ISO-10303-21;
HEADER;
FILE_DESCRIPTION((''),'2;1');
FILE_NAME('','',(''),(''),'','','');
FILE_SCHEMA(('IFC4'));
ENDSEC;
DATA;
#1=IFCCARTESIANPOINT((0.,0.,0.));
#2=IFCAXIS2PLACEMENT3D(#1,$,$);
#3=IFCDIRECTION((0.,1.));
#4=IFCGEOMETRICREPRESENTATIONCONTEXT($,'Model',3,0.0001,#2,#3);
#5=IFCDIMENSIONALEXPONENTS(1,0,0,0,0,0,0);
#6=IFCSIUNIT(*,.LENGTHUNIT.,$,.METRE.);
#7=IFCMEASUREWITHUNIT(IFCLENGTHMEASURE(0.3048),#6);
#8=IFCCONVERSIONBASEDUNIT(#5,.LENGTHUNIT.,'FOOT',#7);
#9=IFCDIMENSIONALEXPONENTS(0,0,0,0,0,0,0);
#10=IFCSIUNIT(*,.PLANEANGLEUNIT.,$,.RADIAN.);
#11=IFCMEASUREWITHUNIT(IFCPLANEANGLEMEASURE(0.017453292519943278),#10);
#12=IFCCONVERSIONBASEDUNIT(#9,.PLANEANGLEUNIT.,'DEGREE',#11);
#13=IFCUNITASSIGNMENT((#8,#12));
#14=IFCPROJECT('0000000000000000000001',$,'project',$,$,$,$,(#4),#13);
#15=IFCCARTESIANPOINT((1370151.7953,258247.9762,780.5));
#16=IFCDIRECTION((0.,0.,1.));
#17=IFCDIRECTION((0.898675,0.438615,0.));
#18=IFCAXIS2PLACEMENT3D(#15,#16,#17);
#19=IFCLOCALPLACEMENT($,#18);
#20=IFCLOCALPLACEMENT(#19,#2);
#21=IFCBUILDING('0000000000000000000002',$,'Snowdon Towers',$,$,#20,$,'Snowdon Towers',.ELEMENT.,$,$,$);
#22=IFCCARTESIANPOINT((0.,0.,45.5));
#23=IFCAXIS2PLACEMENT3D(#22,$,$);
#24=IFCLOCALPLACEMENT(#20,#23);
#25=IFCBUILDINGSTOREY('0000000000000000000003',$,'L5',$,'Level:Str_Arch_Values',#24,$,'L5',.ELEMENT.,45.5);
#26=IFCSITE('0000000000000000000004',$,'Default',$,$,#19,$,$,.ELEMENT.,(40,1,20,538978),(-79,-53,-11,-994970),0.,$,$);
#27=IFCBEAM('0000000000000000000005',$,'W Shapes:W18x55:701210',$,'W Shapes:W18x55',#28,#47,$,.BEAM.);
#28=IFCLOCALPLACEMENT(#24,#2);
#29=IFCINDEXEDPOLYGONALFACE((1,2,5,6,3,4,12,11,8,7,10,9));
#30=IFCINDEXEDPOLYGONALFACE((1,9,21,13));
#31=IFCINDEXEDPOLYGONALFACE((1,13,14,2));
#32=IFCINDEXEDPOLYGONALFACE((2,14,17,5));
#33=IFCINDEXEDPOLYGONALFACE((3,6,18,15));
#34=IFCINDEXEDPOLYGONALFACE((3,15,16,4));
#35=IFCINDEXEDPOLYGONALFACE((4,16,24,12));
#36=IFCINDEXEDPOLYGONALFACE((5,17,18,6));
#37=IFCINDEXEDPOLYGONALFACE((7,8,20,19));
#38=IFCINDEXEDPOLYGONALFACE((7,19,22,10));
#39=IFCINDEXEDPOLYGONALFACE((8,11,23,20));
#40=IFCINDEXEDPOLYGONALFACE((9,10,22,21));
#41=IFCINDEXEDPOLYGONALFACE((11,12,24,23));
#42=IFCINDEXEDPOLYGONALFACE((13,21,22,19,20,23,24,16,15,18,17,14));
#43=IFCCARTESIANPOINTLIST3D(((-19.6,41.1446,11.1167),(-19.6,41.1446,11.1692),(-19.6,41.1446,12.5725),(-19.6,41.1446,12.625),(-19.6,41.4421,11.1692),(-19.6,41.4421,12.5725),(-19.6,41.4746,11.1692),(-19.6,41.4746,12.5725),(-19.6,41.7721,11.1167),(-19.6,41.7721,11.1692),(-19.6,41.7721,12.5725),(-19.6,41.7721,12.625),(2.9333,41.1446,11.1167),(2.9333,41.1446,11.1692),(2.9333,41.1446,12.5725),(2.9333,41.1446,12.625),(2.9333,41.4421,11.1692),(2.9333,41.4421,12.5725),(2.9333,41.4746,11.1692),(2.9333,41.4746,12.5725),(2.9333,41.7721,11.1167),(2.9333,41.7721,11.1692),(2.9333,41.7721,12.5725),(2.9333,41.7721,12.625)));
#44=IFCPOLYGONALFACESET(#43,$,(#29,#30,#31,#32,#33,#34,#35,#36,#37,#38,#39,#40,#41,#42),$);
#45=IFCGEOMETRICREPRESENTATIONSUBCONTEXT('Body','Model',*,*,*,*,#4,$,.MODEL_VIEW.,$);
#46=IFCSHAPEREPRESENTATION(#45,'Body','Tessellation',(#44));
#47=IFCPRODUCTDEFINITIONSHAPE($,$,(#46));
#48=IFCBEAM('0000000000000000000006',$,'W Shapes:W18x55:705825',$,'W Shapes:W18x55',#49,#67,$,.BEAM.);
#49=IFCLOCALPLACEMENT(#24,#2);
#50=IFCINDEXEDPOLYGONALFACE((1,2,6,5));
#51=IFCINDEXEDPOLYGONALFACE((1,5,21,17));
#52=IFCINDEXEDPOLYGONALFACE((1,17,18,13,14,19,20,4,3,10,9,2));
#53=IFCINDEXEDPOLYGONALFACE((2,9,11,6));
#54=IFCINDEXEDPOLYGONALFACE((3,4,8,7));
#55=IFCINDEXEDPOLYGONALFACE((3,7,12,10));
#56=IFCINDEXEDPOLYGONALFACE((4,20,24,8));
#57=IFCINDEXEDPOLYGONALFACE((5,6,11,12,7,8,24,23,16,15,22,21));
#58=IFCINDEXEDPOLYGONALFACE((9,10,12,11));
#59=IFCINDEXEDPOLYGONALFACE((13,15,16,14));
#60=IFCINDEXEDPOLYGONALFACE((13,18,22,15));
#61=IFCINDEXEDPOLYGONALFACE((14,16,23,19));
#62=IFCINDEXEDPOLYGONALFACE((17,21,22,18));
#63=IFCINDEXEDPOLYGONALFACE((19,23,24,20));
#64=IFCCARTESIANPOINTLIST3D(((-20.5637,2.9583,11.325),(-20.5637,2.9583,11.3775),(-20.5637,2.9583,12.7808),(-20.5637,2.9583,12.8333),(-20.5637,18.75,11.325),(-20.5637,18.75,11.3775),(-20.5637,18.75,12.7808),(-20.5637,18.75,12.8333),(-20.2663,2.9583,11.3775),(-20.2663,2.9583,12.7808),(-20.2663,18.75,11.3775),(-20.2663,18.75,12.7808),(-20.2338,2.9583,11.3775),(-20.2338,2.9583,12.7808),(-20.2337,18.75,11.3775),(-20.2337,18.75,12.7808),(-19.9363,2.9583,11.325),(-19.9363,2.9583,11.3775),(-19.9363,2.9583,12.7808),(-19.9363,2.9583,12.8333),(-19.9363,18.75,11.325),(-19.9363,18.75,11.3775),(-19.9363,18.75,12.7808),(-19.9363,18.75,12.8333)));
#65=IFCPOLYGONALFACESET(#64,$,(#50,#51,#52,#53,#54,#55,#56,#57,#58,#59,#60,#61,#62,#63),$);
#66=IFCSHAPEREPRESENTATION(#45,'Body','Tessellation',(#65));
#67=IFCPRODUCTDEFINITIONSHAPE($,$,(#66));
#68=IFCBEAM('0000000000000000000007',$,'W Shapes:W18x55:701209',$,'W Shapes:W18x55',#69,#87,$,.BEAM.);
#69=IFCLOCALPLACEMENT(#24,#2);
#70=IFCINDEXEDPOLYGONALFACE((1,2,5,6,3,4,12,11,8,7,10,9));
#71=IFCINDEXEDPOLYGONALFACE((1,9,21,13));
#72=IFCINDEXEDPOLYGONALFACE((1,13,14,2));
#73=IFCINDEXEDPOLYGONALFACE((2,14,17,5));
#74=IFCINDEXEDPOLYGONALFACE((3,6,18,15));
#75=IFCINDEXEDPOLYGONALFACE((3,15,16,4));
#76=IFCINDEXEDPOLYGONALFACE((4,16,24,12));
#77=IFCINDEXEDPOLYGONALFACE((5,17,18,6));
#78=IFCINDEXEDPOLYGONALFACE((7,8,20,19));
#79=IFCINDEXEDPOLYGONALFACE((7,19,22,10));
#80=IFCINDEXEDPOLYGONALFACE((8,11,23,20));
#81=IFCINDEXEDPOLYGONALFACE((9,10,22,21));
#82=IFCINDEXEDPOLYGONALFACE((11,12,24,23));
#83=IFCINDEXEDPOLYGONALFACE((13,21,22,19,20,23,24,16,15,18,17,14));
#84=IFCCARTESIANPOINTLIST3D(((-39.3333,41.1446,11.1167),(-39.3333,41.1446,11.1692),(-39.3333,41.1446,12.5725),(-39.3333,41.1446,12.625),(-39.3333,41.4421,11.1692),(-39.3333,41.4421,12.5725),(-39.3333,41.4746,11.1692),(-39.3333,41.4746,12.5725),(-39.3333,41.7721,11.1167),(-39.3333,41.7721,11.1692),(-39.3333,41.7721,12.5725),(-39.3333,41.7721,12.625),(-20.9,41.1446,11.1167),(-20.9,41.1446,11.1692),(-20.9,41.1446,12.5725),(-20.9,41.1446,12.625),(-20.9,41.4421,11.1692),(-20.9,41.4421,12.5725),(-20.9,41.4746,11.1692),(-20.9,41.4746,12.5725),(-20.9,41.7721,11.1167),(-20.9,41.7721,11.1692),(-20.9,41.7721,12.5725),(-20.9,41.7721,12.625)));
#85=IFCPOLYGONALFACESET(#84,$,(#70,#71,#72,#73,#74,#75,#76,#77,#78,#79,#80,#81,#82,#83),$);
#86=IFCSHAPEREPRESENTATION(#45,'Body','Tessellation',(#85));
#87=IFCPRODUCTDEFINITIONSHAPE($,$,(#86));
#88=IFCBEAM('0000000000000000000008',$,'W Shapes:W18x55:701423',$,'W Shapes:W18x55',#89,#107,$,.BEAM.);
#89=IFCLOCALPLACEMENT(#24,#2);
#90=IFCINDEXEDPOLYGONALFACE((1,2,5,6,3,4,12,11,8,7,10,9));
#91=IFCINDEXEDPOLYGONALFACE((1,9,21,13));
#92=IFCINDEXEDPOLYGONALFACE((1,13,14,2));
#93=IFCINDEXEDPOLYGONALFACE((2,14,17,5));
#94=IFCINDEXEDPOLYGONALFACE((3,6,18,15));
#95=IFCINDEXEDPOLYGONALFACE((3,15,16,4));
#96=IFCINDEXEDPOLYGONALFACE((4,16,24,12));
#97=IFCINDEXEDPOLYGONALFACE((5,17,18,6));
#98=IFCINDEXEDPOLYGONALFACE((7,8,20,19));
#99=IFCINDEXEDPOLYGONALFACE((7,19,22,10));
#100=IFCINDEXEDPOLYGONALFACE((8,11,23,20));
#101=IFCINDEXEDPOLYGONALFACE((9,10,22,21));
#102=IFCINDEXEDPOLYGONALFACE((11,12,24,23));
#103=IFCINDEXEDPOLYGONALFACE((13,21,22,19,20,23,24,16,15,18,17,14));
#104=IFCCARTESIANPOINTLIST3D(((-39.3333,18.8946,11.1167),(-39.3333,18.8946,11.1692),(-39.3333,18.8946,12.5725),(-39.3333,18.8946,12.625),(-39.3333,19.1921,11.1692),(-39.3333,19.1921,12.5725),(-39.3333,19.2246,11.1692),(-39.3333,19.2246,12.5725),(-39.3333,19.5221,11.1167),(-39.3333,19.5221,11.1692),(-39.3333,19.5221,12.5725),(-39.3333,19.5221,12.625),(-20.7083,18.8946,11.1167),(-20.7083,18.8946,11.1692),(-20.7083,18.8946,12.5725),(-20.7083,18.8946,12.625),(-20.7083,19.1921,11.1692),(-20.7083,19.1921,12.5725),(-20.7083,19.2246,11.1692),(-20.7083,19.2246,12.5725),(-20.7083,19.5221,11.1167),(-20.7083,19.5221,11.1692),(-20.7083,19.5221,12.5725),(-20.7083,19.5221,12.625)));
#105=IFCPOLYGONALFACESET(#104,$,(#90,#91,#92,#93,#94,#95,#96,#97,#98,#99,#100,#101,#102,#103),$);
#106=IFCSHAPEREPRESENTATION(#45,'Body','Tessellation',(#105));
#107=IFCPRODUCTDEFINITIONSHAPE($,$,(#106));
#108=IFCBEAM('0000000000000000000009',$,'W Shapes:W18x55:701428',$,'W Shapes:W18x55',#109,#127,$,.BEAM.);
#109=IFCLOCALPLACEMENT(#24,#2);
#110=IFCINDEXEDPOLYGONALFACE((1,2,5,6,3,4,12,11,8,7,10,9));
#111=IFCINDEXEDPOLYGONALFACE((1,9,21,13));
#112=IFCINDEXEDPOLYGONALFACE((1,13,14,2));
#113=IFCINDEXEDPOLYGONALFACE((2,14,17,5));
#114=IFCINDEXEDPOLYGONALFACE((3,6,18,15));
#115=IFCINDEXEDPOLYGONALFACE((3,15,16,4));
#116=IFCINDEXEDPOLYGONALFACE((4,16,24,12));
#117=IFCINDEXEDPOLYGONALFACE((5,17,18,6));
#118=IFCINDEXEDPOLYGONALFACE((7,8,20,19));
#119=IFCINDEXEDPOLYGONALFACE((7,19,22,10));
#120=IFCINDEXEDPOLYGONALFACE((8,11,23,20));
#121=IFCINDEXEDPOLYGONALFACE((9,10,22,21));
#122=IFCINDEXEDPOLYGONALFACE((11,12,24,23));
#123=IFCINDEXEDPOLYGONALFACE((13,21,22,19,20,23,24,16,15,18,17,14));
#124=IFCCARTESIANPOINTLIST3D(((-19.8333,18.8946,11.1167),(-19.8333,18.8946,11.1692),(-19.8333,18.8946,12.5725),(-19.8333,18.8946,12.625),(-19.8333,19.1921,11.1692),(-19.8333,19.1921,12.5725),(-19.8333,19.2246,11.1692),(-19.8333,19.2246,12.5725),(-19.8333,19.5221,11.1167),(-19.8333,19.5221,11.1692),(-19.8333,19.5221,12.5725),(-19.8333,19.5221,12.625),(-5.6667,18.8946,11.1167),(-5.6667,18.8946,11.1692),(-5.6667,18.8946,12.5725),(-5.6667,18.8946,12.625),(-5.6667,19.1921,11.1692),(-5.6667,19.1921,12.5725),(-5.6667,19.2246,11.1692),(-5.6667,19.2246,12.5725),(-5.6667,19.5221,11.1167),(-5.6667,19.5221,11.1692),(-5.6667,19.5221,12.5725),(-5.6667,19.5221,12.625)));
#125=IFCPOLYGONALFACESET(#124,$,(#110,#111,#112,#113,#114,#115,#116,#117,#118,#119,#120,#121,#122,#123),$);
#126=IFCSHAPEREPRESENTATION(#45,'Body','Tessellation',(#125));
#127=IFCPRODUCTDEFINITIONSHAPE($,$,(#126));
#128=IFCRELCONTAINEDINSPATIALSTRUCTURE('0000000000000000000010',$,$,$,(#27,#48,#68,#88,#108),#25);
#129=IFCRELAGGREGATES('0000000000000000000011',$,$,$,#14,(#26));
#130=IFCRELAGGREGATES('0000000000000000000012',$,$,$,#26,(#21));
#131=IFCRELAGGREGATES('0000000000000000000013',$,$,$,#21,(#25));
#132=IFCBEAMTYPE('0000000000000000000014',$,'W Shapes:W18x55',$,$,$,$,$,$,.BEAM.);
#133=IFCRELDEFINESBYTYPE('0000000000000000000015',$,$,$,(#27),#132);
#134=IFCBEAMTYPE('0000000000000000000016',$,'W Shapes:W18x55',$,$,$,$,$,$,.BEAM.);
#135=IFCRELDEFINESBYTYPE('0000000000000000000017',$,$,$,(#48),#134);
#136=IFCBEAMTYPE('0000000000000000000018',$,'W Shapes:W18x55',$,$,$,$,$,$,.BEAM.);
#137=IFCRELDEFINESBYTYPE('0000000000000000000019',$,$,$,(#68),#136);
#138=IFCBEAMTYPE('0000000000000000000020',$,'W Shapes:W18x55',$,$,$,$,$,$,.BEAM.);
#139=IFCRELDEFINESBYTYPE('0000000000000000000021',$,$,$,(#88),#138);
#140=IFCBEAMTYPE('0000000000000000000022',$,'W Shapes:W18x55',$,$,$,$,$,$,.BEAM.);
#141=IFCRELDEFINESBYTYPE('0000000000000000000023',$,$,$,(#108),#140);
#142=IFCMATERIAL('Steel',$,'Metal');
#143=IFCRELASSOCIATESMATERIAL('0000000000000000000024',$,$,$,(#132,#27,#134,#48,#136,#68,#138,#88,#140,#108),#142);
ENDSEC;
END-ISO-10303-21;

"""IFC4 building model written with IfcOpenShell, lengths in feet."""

from ifc_helpers import new_model, entity, si_unit, converted_unit, direction, frame, origin, place, context, subcontext, project, spatial, indexed_curve, outline, extrude, source, transform, mapped, material, type_object, type_shapes, element, save


model = new_model("IFC4")

# Units and contexts
model_context = context("Model", 3, precision=0.0001, world=origin(), true_north=direction((0.0, 1.0)))
body_context = subcontext(model_context, "Body", "Model", "MODEL_VIEW")
ifc_project = project(units=[converted_unit("LENGTHUNIT", "FOOT", entity("IfcLengthMeasure", 0.3048), si_unit("LENGTHUNIT", "METRE"), dimensions=[1, 0, 0, 0, 0, 0, 0]), converted_unit("PLANEANGLEUNIT", "DEGREE", entity("IfcPlaneAngleMeasure", 0.017453292519943278), si_unit("PLANEANGLEUNIT", "RADIAN"), dimensions=[0, 0, 0, 0, 0, 0, 0])], contexts=[model_context])

# Site, building, storey
site_placement = place(None, frame((1370151.7953, 258247.9762, 780.5), z_axis=(0.0, 0.0, 1.0), x_axis=(0.898675, 0.438615, 0.0)))
site = spatial("IfcSite", under=ifc_project, at=site_placement, Name="Default", CompositionType="ELEMENT", RefLatitude=(40, 1, 20, 538978), RefLongitude=(-79, -53, -11, -994970), RefElevation=0.0)
building_placement = place(site_placement, origin())
building = spatial("IfcBuilding", under=site, at=building_placement, Name="Snowdon Towers", LongName="Snowdon Towers", CompositionType="ELEMENT")
storey_placement = place(building_placement, frame((0.0, 0.0, 45.5)))
storey = spatial("IfcBuildingStorey", under=building, at=storey_placement, Name="L5", ObjectType="Level:Str_Arch_Values", LongName="L5", CompositionType="ELEMENT", Elevation=45.5)

# Beams
ifc_material = material(Name="Steel", Category="Metal")
beam_type_1 = type_object("IfcBeamType", Name="W Shapes:W18x55", PredefinedType="BEAM", material=ifc_material)
shared_shape_1 = source(origin(), body_context, "Body", "SweptSolid", [
    extrude(outline(indexed_curve([(-0.3138, -0.7017), (-0.3138, -0.7542), (0.3138, -0.7542), (0.3138, -0.7017), (0.0162, -0.7017), (0.0162, 0.7017), (0.3138, 0.7017), (0.3138, 0.7542), (-0.3137, 0.7542), (-0.3137, 0.7017), (-0.0163, 0.7017), (-0.0163, -0.7017), (-0.3138, -0.7017)], self_intersect=False)), frame((-11.35, 0.0, 0.0), z_axis=(-1.0, 0.0, 0.0), x_axis=(0.0, -1.0, 0.0)), (0.0, 0.0, -1.0), 22.5333),
])
type_shapes(beam_type_1, [shared_shape_1])
beam_1_placement = place(storey_placement, frame((-8.25, 41.4583, 11.8708)))
element("IfcBeam", 1, at=beam_1_placement, inside=storey, type_object=beam_type_1, material=ifc_material, Name="W Shapes:W18x55:701210", ObjectType="W Shapes:W18x55", PredefinedType="BEAM", context=body_context, shape_type="MappedRepresentation", body=[
    mapped(shared_shape_1, transform((0.0, 0.0, 0.0), scale=1.0)),
])
beam_type_2 = type_object("IfcBeamType", Name="W Shapes:W18x55", PredefinedType="BEAM", material=ifc_material)
shared_shape_2 = source(origin(), body_context, "Body", "SweptSolid", [
    extrude(outline(indexed_curve([(-0.3138, -0.7017), (-0.3138, -0.7542), (0.3138, -0.7542), (0.3138, -0.7017), (0.0162, -0.7017), (0.0162, 0.7017), (0.3138, 0.7017), (0.3138, 0.7542), (-0.3137, 0.7542), (-0.3137, 0.7017), (-0.0163, 0.7017), (-0.0163, -0.7017), (-0.3138, -0.7017)], self_intersect=False)), frame((-7.8958, 0.0, 0.0), z_axis=(-1.0, 0.0, 0.0), x_axis=(0.0, -1.0, 0.0)), (0.0, 0.0, -1.0), 15.7917),
])
type_shapes(beam_type_2, [shared_shape_2])
beam_2_placement = place(storey_placement, frame((-20.25, 10.8542, 12.0792), z_axis=(0.0, 0.0, 1.0), x_axis=(0.0, 1.0, 0.0)))
element("IfcBeam", 2, at=beam_2_placement, inside=storey, type_object=beam_type_2, material=ifc_material, Name="W Shapes:W18x55:705825", ObjectType="W Shapes:W18x55", PredefinedType="BEAM", context=body_context, shape_type="MappedRepresentation", body=[
    mapped(shared_shape_2, transform((0.0, 0.0, 0.0), scale=1.0)),
])
beam_type_3 = type_object("IfcBeamType", Name="W Shapes:W18x55", PredefinedType="BEAM", material=ifc_material)
shared_shape_3 = source(origin(), body_context, "Body", "SweptSolid", [
    extrude(outline(indexed_curve([(-0.3138, -0.7017), (-0.3138, -0.7542), (0.3138, -0.7542), (0.3138, -0.7017), (0.0162, -0.7017), (0.0162, 0.7017), (0.3138, 0.7017), (0.3138, 0.7542), (-0.3137, 0.7542), (-0.3137, 0.7017), (-0.0163, 0.7017), (-0.0163, -0.7017), (-0.3138, -0.7017)], self_intersect=False)), frame((-9.2708, 0.0, 0.0), z_axis=(-1.0, 0.0, 0.0), x_axis=(0.0, -1.0, 0.0)), (0.0, 0.0, -1.0), 18.4333),
])
type_shapes(beam_type_3, [shared_shape_3])
beam_3_placement = place(storey_placement, frame((-30.0625, 41.4583, 11.8708)))
element("IfcBeam", 3, at=beam_3_placement, inside=storey, type_object=beam_type_3, material=ifc_material, Name="W Shapes:W18x55:701209", ObjectType="W Shapes:W18x55", PredefinedType="BEAM", context=body_context, shape_type="MappedRepresentation", body=[
    mapped(shared_shape_3, transform((0.0, 0.0, 0.0), scale=1.0)),
])
beam_type_4 = type_object("IfcBeamType", Name="W Shapes:W18x55", PredefinedType="BEAM", material=ifc_material)
shared_shape_4 = source(origin(), body_context, "Body", "SweptSolid", [
    extrude(outline(indexed_curve([(-0.3138, -0.7017), (-0.3138, -0.7542), (0.3138, -0.7542), (0.3138, -0.7017), (0.0162, -0.7017), (0.0162, 0.7017), (0.3138, 0.7017), (0.3138, 0.7542), (-0.3137, 0.7542), (-0.3137, 0.7017), (-0.0163, 0.7017), (-0.0163, -0.7017), (-0.3138, -0.7017)], self_intersect=False)), frame((-9.2708, 0.0, 0.0), z_axis=(-1.0, 0.0, 0.0), x_axis=(0.0, -1.0, 0.0)), (0.0, 0.0, -1.0), 18.625),
])
type_shapes(beam_type_4, [shared_shape_4])
beam_4_placement = place(storey_placement, frame((-30.0625, 19.2083, 11.8708)))
element("IfcBeam", 4, at=beam_4_placement, inside=storey, type_object=beam_type_4, material=ifc_material, Name="W Shapes:W18x55:701423", ObjectType="W Shapes:W18x55", PredefinedType="BEAM", context=body_context, shape_type="MappedRepresentation", body=[
    mapped(shared_shape_4, transform((0.0, 0.0, 0.0), scale=1.0)),
])
beam_type_5 = type_object("IfcBeamType", Name="W Shapes:W18x55", PredefinedType="BEAM", material=ifc_material)
shared_shape_5 = source(origin(), body_context, "Body", "SweptSolid", [
    extrude(outline(indexed_curve([(-0.3138, -0.7017), (-0.3138, -0.7542), (0.3138, -0.7542), (0.3138, -0.7017), (0.0162, -0.7017), (0.0162, 0.7017), (0.3138, 0.7017), (0.3138, 0.7542), (-0.3137, 0.7542), (-0.3137, 0.7017), (-0.0163, 0.7017), (-0.0163, -0.7017), (-0.3138, -0.7017)], self_intersect=False)), frame((-7.2917, 0.0, 0.0), z_axis=(-1.0, 0.0, 0.0), x_axis=(0.0, -1.0, 0.0)), (0.0, 0.0, -1.0), 14.1667),
])
type_shapes(beam_type_5, [shared_shape_5])
beam_5_placement = place(storey_placement, frame((-12.9583, 19.2083, 11.8708), z_axis=(0.0, 0.0, 1.0), x_axis=(-1.0, 0.0, 0.0)))
element("IfcBeam", 5, at=beam_5_placement, inside=storey, type_object=beam_type_5, material=ifc_material, Name="W Shapes:W18x55:701428", ObjectType="W Shapes:W18x55", PredefinedType="BEAM", context=body_context, shape_type="MappedRepresentation", body=[
    mapped(shared_shape_5, transform((0.0, 0.0, 0.0), scale=1.0)),
])

save(model, "model.ifc")
